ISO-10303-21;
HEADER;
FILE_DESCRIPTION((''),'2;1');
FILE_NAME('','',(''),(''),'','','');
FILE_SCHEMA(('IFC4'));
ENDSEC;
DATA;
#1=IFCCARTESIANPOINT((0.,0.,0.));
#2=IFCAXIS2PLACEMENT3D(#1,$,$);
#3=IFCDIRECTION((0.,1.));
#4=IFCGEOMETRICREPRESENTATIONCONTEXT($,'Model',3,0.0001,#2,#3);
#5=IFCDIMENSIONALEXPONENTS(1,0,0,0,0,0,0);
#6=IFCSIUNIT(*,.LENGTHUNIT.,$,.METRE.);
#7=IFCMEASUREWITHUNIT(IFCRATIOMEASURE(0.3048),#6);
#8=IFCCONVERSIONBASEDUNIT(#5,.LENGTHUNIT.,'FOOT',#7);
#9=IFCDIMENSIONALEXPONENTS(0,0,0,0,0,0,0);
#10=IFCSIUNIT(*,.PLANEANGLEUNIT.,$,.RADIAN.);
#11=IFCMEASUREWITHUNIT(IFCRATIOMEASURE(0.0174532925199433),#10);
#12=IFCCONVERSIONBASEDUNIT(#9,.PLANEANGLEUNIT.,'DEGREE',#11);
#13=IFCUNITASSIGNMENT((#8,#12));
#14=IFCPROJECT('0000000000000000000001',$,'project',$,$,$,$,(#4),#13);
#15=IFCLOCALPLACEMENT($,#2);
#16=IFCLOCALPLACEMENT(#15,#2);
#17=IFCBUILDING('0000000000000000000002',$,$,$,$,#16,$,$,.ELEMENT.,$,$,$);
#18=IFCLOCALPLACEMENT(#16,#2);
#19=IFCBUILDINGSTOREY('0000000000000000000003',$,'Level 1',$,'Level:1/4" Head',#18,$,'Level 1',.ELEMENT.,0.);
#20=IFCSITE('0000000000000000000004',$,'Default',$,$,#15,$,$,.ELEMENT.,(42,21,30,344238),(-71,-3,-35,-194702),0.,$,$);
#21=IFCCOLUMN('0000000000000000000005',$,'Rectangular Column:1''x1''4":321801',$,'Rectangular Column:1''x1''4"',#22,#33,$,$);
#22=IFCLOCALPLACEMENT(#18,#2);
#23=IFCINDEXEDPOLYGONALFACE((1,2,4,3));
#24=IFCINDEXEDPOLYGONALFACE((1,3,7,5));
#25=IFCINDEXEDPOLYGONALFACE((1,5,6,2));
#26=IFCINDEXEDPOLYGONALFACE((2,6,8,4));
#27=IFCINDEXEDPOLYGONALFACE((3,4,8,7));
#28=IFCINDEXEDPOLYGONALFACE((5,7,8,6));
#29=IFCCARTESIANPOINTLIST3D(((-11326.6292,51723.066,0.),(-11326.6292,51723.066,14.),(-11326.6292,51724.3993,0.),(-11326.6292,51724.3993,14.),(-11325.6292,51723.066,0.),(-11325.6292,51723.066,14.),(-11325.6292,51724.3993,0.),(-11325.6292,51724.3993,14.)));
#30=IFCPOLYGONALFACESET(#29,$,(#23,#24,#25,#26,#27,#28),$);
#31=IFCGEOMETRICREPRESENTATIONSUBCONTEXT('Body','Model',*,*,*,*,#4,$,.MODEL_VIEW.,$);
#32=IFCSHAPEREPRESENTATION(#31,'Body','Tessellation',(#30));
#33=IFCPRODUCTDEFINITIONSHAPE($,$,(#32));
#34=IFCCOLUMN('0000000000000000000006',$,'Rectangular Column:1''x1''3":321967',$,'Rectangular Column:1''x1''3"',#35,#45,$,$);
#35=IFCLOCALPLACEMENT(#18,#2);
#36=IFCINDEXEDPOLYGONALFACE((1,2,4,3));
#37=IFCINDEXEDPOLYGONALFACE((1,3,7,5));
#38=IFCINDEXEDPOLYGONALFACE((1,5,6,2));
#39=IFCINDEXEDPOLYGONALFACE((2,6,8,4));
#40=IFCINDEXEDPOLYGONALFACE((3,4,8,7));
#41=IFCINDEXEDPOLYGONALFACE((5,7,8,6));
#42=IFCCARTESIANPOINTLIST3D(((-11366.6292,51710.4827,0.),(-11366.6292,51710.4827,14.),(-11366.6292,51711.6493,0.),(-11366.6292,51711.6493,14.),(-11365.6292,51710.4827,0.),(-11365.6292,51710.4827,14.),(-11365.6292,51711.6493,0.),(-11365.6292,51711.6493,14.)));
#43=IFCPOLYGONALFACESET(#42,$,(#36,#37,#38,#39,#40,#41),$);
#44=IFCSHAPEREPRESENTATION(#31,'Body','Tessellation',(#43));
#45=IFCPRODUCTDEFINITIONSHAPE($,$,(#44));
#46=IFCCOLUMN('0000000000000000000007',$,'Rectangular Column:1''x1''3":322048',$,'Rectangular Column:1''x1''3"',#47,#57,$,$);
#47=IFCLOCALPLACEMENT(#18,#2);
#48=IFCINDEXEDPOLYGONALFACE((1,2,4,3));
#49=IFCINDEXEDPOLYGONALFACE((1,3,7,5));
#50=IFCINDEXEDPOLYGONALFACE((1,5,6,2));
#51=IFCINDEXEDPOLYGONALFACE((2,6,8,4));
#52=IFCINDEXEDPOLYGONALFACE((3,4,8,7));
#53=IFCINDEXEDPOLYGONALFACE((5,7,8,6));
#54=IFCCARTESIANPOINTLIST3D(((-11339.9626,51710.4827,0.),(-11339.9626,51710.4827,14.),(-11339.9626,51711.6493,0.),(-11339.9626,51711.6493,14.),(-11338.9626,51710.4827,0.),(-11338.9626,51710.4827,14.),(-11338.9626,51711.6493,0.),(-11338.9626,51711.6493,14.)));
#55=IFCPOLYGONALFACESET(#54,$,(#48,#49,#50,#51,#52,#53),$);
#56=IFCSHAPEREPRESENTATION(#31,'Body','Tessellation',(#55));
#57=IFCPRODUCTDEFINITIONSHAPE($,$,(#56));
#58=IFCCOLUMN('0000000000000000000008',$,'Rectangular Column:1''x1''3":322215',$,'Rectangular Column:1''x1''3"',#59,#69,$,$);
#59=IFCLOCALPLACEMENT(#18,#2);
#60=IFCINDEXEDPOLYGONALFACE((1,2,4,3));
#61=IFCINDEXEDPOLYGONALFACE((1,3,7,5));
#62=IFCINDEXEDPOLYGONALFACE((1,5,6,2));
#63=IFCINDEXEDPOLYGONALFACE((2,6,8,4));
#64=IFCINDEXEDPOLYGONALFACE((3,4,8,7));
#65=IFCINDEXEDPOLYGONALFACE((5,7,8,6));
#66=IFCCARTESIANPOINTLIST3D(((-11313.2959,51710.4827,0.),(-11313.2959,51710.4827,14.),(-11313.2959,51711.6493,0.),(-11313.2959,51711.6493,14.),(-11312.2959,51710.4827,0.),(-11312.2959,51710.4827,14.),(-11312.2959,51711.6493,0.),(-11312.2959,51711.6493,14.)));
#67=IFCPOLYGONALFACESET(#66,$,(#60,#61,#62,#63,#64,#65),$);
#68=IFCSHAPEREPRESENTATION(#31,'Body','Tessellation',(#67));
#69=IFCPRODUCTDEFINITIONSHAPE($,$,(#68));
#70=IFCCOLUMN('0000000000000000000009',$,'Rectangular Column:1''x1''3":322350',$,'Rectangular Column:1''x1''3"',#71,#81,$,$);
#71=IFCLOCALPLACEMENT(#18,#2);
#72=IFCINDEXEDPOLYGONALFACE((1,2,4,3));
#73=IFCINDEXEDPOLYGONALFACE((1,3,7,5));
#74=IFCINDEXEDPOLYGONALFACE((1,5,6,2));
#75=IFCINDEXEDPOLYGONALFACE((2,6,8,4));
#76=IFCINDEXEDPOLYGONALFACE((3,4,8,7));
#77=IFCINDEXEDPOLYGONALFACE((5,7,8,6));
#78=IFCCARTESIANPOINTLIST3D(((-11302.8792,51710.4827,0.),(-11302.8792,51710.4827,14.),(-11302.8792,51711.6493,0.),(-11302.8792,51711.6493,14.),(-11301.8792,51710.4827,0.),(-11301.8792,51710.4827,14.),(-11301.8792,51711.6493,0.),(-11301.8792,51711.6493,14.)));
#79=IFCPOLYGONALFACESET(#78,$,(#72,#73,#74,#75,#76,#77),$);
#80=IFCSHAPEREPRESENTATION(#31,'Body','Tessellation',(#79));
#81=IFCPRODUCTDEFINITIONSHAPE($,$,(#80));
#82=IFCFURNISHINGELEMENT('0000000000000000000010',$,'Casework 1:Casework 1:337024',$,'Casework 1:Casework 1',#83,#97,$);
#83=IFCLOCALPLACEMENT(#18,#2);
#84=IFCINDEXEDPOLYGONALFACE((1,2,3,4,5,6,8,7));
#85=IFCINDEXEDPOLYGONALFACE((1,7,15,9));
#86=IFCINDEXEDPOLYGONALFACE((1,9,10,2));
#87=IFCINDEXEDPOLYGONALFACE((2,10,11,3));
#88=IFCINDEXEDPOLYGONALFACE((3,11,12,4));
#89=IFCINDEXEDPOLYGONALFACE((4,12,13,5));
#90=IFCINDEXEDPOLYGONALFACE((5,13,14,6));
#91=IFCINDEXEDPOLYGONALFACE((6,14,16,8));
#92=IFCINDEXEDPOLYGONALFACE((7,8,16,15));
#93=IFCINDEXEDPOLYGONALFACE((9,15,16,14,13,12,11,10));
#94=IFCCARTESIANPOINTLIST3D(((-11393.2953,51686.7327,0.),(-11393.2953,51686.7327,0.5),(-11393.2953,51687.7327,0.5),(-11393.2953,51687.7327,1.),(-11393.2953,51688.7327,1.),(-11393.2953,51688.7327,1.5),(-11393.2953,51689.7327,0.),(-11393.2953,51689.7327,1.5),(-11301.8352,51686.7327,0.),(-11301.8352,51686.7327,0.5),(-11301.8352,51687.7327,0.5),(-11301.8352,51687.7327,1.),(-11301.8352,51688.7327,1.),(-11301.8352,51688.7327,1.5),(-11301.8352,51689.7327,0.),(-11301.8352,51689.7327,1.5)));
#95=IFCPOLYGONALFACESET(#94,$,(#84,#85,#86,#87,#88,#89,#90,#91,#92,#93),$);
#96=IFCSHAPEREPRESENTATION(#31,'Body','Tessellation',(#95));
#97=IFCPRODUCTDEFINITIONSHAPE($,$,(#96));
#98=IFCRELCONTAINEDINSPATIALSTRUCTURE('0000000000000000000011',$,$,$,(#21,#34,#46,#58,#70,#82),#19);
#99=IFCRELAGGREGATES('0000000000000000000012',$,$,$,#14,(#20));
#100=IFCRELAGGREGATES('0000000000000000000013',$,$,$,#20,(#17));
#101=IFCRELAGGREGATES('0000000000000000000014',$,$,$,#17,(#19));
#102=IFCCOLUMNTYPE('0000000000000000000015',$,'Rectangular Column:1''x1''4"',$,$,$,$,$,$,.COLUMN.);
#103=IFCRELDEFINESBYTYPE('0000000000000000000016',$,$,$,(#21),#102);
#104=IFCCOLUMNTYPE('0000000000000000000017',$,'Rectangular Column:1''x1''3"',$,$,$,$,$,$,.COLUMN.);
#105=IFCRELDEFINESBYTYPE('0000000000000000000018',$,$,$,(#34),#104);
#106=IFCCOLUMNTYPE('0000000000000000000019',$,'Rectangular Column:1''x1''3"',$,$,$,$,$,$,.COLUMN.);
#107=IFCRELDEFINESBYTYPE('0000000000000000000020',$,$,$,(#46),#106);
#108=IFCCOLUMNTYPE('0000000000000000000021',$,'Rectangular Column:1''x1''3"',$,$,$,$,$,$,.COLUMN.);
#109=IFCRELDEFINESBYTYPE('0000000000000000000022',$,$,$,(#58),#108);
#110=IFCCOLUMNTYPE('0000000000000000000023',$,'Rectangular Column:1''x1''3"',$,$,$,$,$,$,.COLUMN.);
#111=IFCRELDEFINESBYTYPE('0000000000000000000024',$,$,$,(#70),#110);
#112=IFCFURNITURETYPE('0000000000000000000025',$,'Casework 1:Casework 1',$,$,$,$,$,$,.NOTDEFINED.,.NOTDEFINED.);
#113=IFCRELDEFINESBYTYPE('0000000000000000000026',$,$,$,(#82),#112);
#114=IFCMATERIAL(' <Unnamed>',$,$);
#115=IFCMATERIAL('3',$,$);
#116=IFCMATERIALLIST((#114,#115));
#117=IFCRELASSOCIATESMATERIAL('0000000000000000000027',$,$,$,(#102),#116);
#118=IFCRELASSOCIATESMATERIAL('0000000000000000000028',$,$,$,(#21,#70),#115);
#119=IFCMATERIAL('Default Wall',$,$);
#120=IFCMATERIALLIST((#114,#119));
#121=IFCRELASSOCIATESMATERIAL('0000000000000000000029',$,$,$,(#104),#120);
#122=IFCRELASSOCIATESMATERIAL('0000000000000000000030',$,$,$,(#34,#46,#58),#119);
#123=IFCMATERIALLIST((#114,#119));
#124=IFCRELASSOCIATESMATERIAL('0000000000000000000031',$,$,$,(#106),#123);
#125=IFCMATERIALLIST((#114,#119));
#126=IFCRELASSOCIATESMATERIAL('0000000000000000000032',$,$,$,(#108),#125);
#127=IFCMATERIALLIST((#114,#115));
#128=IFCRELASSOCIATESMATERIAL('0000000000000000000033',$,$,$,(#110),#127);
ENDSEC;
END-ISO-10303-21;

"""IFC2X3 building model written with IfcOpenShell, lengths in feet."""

from ifc_helpers import new_model, entity, si_unit, converted_unit, direction, frame, frame_2d, origin, place, context, subcontext, project, spatial, polyline, rectangle, outline, extrude, source, transform, mapped, material, material_list, type_object, type_shapes, element, save


model = new_model("IFC2X3")

# Units and contexts
model_context = context("Model", 3, precision=0.0001, world=origin(), true_north=direction((0.0, 1.0)))
body_context = subcontext(model_context, "Body", "Model", "MODEL_VIEW")
ifc_project = project(units=[converted_unit("LENGTHUNIT", "FOOT", entity("IfcRatioMeasure", 0.3048), si_unit("LENGTHUNIT", "METRE"), dimensions=[1, 0, 0, 0, 0, 0, 0]), converted_unit("PLANEANGLEUNIT", "DEGREE", entity("IfcRatioMeasure", 0.0174532925199433), si_unit("PLANEANGLEUNIT", "RADIAN"), dimensions=[0, 0, 0, 0, 0, 0, 0])], contexts=[model_context])

# Site, building, storey
site_placement = place(None, origin())
site = spatial("IfcSite", under=ifc_project, at=site_placement, Name="Default", CompositionType="ELEMENT", RefLatitude=(42, 21, 30, 344238), RefLongitude=(-71, -3, -35, -194702), RefElevation=0.0)
building_placement = place(site_placement, origin())
building = spatial("IfcBuilding", under=site, at=building_placement, CompositionType="ELEMENT")
storey_placement = place(building_placement, origin())
storey = spatial("IfcBuildingStorey", under=building, at=storey_placement, Name="Level 1", ObjectType="Level:1/4\" Head", LongName="Level 1", CompositionType="ELEMENT", Elevation=0.0)

# Columns
ifc_material_1 = material(Name="3")
ifc_material_2 = material(Name=" <Unnamed>")
ifc_material_3 = material(Name="Default Wall")
ifc_material_list_1 = material_list([ifc_material_2, ifc_material_1])
column_type_1 = type_object("IfcColumnType", Name="Rectangular Column:1'x1'4\"", PredefinedType="COLUMN", material=ifc_material_list_1)
shared_shape_1 = source(origin(), body_context, "Body", "SweptSolid", [
    extrude(rectangle(XDim=1.3333, YDim=1.0, at=frame_2d((0.0, 0.0), x_axis=(1.0, 0.0))), frame((-11326.1292, 51723.7327, 0.0), z_axis=(0.0, 0.0, 1.0), x_axis=(0.0, -1.0, 0.0)), (0.0, 0.0, 1.0), 14.0),
])
type_shapes(column_type_1, [shared_shape_1])
column_1_placement = place(storey_placement, origin())
element("IfcColumn", 1, at=column_1_placement, inside=storey, type_object=column_type_1, material=ifc_material_1, Name="Rectangular Column:1'x1'4\":321801", ObjectType="Rectangular Column:1'x1'4\"", context=body_context, shape_type="MappedRepresentation", body=[
    mapped(shared_shape_1, transform((0.0, 0.0, 0.0), scale=1.0)),
])
ifc_material_list_2 = material_list([ifc_material_2, ifc_material_3])
column_type_2 = type_object("IfcColumnType", Name="Rectangular Column:1'x1'3\"", PredefinedType="COLUMN", material=ifc_material_list_2)
shared_shape_2 = source(origin(), body_context, "Body", "SweptSolid", [
    extrude(rectangle(XDim=1.1667, YDim=1.0, at=frame_2d((0.0, 0.0), x_axis=(1.0, 0.0))), frame((-11366.1292, 51711.066, 0.0), z_axis=(0.0, 0.0, 1.0), x_axis=(0.0, -1.0, 0.0)), (0.0, 0.0, 1.0), 14.0),
])
type_shapes(column_type_2, [shared_shape_2])
column_2_placement = place(storey_placement, origin())
element("IfcColumn", 2, at=column_2_placement, inside=storey, type_object=column_type_2, material=ifc_material_3, Name="Rectangular Column:1'x1'3\":321967", ObjectType="Rectangular Column:1'x1'3\"", context=body_context, shape_type="MappedRepresentation", body=[
    mapped(shared_shape_2, transform((0.0, 0.0, 0.0), scale=1.0)),
])
ifc_material_list_3 = material_list([ifc_material_2, ifc_material_3])
column_type_3 = type_object("IfcColumnType", Name="Rectangular Column:1'x1'3\"", PredefinedType="COLUMN", material=ifc_material_list_3)
shared_shape_3 = source(origin(), body_context, "Body", "SweptSolid", [
    extrude(rectangle(XDim=1.1667, YDim=1.0, at=frame_2d((0.0, 0.0), x_axis=(1.0, 0.0))), frame((-11339.4626, 51711.066, 0.0), z_axis=(0.0, 0.0, 1.0), x_axis=(0.0, -1.0, 0.0)), (0.0, 0.0, 1.0), 14.0),
])
type_shapes(column_type_3, [shared_shape_3])
column_3_placement = place(storey_placement, origin())
element("IfcColumn", 3, at=column_3_placement, inside=storey, type_object=column_type_3, material=ifc_material_3, Name="Rectangular Column:1'x1'3\":322048", ObjectType="Rectangular Column:1'x1'3\"", context=body_context, shape_type="MappedRepresentation", body=[
    mapped(shared_shape_3, transform((0.0, 0.0, 0.0), scale=1.0)),
])
ifc_material_list_4 = material_list([ifc_material_2, ifc_material_3])
column_type_4 = type_object("IfcColumnType", Name="Rectangular Column:1'x1'3\"", PredefinedType="COLUMN", material=ifc_material_list_4)
shared_shape_4 = source(origin(), body_context, "Body", "SweptSolid", [
    extrude(rectangle(XDim=1.1667, YDim=1.0, at=frame_2d((0.0, 0.0), x_axis=(1.0, 0.0))), frame((-11312.7959, 51711.066, 0.0), z_axis=(0.0, 0.0, 1.0), x_axis=(0.0, -1.0, 0.0)), (0.0, 0.0, 1.0), 14.0),
])
type_shapes(column_type_4, [shared_shape_4])
column_4_placement = place(storey_placement, origin())
element("IfcColumn", 4, at=column_4_placement, inside=storey, type_object=column_type_4, material=ifc_material_3, Name="Rectangular Column:1'x1'3\":322215", ObjectType="Rectangular Column:1'x1'3\"", context=body_context, shape_type="MappedRepresentation", body=[
    mapped(shared_shape_4, transform((0.0, 0.0, 0.0), scale=1.0)),
])
ifc_material_list_5 = material_list([ifc_material_2, ifc_material_1])
column_type_5 = type_object("IfcColumnType", Name="Rectangular Column:1'x1'3\"", PredefinedType="COLUMN", material=ifc_material_list_5)
shared_shape_5 = source(origin(), body_context, "Body", "SweptSolid", [
    extrude(rectangle(XDim=1.1667, YDim=1.0, at=frame_2d((0.0, 0.0), x_axis=(1.0, 0.0))), frame((-11302.3792, 51711.066, 0.0), z_axis=(0.0, 0.0, 1.0), x_axis=(0.0, -1.0, 0.0)), (0.0, 0.0, 1.0), 14.0),
])
type_shapes(column_type_5, [shared_shape_5])
column_5_placement = place(storey_placement, origin())
element("IfcColumn", 5, at=column_5_placement, inside=storey, type_object=column_type_5, material=ifc_material_1, Name="Rectangular Column:1'x1'3\":322350", ObjectType="Rectangular Column:1'x1'3\"", context=body_context, shape_type="MappedRepresentation", body=[
    mapped(shared_shape_5, transform((0.0, 0.0, 0.0), scale=1.0)),
])

# Furnishing element
furniture_type = type_object("IfcFurnitureType", Name="Casework 1:Casework 1")
shared_shape_6 = source(origin(), body_context, "Body", "SweptSolid", [
    extrude(outline(polyline([(-0.75, -1.5), (0.75, -1.5), (0.75, -0.5), (0.25, -0.5), (0.25, 0.5), (-0.25, 0.5), (-0.25, 1.5), (-0.75, 1.5), (-0.75, -1.5)])), frame((-11393.2953, 51688.2327, 0.75), z_axis=(1.0, 0.0, 0.0), x_axis=(0.0, 0.0, 1.0)), (0.0, 0.0, 1.0), 91.4601),
])
type_shapes(furniture_type, [shared_shape_6])
furnishing_placement = place(storey_placement, origin())
element("IfcFurnishingElement", 6, at=furnishing_placement, inside=storey, type_object=furniture_type, Name="Casework 1:Casework 1:337024", ObjectType="Casework 1:Casework 1", context=body_context, shape_type="MappedRepresentation", body=[
    mapped(shared_shape_6, transform((0.0, 0.0, 0.0), scale=1.0)),
])

save(model, "model.ifc")
